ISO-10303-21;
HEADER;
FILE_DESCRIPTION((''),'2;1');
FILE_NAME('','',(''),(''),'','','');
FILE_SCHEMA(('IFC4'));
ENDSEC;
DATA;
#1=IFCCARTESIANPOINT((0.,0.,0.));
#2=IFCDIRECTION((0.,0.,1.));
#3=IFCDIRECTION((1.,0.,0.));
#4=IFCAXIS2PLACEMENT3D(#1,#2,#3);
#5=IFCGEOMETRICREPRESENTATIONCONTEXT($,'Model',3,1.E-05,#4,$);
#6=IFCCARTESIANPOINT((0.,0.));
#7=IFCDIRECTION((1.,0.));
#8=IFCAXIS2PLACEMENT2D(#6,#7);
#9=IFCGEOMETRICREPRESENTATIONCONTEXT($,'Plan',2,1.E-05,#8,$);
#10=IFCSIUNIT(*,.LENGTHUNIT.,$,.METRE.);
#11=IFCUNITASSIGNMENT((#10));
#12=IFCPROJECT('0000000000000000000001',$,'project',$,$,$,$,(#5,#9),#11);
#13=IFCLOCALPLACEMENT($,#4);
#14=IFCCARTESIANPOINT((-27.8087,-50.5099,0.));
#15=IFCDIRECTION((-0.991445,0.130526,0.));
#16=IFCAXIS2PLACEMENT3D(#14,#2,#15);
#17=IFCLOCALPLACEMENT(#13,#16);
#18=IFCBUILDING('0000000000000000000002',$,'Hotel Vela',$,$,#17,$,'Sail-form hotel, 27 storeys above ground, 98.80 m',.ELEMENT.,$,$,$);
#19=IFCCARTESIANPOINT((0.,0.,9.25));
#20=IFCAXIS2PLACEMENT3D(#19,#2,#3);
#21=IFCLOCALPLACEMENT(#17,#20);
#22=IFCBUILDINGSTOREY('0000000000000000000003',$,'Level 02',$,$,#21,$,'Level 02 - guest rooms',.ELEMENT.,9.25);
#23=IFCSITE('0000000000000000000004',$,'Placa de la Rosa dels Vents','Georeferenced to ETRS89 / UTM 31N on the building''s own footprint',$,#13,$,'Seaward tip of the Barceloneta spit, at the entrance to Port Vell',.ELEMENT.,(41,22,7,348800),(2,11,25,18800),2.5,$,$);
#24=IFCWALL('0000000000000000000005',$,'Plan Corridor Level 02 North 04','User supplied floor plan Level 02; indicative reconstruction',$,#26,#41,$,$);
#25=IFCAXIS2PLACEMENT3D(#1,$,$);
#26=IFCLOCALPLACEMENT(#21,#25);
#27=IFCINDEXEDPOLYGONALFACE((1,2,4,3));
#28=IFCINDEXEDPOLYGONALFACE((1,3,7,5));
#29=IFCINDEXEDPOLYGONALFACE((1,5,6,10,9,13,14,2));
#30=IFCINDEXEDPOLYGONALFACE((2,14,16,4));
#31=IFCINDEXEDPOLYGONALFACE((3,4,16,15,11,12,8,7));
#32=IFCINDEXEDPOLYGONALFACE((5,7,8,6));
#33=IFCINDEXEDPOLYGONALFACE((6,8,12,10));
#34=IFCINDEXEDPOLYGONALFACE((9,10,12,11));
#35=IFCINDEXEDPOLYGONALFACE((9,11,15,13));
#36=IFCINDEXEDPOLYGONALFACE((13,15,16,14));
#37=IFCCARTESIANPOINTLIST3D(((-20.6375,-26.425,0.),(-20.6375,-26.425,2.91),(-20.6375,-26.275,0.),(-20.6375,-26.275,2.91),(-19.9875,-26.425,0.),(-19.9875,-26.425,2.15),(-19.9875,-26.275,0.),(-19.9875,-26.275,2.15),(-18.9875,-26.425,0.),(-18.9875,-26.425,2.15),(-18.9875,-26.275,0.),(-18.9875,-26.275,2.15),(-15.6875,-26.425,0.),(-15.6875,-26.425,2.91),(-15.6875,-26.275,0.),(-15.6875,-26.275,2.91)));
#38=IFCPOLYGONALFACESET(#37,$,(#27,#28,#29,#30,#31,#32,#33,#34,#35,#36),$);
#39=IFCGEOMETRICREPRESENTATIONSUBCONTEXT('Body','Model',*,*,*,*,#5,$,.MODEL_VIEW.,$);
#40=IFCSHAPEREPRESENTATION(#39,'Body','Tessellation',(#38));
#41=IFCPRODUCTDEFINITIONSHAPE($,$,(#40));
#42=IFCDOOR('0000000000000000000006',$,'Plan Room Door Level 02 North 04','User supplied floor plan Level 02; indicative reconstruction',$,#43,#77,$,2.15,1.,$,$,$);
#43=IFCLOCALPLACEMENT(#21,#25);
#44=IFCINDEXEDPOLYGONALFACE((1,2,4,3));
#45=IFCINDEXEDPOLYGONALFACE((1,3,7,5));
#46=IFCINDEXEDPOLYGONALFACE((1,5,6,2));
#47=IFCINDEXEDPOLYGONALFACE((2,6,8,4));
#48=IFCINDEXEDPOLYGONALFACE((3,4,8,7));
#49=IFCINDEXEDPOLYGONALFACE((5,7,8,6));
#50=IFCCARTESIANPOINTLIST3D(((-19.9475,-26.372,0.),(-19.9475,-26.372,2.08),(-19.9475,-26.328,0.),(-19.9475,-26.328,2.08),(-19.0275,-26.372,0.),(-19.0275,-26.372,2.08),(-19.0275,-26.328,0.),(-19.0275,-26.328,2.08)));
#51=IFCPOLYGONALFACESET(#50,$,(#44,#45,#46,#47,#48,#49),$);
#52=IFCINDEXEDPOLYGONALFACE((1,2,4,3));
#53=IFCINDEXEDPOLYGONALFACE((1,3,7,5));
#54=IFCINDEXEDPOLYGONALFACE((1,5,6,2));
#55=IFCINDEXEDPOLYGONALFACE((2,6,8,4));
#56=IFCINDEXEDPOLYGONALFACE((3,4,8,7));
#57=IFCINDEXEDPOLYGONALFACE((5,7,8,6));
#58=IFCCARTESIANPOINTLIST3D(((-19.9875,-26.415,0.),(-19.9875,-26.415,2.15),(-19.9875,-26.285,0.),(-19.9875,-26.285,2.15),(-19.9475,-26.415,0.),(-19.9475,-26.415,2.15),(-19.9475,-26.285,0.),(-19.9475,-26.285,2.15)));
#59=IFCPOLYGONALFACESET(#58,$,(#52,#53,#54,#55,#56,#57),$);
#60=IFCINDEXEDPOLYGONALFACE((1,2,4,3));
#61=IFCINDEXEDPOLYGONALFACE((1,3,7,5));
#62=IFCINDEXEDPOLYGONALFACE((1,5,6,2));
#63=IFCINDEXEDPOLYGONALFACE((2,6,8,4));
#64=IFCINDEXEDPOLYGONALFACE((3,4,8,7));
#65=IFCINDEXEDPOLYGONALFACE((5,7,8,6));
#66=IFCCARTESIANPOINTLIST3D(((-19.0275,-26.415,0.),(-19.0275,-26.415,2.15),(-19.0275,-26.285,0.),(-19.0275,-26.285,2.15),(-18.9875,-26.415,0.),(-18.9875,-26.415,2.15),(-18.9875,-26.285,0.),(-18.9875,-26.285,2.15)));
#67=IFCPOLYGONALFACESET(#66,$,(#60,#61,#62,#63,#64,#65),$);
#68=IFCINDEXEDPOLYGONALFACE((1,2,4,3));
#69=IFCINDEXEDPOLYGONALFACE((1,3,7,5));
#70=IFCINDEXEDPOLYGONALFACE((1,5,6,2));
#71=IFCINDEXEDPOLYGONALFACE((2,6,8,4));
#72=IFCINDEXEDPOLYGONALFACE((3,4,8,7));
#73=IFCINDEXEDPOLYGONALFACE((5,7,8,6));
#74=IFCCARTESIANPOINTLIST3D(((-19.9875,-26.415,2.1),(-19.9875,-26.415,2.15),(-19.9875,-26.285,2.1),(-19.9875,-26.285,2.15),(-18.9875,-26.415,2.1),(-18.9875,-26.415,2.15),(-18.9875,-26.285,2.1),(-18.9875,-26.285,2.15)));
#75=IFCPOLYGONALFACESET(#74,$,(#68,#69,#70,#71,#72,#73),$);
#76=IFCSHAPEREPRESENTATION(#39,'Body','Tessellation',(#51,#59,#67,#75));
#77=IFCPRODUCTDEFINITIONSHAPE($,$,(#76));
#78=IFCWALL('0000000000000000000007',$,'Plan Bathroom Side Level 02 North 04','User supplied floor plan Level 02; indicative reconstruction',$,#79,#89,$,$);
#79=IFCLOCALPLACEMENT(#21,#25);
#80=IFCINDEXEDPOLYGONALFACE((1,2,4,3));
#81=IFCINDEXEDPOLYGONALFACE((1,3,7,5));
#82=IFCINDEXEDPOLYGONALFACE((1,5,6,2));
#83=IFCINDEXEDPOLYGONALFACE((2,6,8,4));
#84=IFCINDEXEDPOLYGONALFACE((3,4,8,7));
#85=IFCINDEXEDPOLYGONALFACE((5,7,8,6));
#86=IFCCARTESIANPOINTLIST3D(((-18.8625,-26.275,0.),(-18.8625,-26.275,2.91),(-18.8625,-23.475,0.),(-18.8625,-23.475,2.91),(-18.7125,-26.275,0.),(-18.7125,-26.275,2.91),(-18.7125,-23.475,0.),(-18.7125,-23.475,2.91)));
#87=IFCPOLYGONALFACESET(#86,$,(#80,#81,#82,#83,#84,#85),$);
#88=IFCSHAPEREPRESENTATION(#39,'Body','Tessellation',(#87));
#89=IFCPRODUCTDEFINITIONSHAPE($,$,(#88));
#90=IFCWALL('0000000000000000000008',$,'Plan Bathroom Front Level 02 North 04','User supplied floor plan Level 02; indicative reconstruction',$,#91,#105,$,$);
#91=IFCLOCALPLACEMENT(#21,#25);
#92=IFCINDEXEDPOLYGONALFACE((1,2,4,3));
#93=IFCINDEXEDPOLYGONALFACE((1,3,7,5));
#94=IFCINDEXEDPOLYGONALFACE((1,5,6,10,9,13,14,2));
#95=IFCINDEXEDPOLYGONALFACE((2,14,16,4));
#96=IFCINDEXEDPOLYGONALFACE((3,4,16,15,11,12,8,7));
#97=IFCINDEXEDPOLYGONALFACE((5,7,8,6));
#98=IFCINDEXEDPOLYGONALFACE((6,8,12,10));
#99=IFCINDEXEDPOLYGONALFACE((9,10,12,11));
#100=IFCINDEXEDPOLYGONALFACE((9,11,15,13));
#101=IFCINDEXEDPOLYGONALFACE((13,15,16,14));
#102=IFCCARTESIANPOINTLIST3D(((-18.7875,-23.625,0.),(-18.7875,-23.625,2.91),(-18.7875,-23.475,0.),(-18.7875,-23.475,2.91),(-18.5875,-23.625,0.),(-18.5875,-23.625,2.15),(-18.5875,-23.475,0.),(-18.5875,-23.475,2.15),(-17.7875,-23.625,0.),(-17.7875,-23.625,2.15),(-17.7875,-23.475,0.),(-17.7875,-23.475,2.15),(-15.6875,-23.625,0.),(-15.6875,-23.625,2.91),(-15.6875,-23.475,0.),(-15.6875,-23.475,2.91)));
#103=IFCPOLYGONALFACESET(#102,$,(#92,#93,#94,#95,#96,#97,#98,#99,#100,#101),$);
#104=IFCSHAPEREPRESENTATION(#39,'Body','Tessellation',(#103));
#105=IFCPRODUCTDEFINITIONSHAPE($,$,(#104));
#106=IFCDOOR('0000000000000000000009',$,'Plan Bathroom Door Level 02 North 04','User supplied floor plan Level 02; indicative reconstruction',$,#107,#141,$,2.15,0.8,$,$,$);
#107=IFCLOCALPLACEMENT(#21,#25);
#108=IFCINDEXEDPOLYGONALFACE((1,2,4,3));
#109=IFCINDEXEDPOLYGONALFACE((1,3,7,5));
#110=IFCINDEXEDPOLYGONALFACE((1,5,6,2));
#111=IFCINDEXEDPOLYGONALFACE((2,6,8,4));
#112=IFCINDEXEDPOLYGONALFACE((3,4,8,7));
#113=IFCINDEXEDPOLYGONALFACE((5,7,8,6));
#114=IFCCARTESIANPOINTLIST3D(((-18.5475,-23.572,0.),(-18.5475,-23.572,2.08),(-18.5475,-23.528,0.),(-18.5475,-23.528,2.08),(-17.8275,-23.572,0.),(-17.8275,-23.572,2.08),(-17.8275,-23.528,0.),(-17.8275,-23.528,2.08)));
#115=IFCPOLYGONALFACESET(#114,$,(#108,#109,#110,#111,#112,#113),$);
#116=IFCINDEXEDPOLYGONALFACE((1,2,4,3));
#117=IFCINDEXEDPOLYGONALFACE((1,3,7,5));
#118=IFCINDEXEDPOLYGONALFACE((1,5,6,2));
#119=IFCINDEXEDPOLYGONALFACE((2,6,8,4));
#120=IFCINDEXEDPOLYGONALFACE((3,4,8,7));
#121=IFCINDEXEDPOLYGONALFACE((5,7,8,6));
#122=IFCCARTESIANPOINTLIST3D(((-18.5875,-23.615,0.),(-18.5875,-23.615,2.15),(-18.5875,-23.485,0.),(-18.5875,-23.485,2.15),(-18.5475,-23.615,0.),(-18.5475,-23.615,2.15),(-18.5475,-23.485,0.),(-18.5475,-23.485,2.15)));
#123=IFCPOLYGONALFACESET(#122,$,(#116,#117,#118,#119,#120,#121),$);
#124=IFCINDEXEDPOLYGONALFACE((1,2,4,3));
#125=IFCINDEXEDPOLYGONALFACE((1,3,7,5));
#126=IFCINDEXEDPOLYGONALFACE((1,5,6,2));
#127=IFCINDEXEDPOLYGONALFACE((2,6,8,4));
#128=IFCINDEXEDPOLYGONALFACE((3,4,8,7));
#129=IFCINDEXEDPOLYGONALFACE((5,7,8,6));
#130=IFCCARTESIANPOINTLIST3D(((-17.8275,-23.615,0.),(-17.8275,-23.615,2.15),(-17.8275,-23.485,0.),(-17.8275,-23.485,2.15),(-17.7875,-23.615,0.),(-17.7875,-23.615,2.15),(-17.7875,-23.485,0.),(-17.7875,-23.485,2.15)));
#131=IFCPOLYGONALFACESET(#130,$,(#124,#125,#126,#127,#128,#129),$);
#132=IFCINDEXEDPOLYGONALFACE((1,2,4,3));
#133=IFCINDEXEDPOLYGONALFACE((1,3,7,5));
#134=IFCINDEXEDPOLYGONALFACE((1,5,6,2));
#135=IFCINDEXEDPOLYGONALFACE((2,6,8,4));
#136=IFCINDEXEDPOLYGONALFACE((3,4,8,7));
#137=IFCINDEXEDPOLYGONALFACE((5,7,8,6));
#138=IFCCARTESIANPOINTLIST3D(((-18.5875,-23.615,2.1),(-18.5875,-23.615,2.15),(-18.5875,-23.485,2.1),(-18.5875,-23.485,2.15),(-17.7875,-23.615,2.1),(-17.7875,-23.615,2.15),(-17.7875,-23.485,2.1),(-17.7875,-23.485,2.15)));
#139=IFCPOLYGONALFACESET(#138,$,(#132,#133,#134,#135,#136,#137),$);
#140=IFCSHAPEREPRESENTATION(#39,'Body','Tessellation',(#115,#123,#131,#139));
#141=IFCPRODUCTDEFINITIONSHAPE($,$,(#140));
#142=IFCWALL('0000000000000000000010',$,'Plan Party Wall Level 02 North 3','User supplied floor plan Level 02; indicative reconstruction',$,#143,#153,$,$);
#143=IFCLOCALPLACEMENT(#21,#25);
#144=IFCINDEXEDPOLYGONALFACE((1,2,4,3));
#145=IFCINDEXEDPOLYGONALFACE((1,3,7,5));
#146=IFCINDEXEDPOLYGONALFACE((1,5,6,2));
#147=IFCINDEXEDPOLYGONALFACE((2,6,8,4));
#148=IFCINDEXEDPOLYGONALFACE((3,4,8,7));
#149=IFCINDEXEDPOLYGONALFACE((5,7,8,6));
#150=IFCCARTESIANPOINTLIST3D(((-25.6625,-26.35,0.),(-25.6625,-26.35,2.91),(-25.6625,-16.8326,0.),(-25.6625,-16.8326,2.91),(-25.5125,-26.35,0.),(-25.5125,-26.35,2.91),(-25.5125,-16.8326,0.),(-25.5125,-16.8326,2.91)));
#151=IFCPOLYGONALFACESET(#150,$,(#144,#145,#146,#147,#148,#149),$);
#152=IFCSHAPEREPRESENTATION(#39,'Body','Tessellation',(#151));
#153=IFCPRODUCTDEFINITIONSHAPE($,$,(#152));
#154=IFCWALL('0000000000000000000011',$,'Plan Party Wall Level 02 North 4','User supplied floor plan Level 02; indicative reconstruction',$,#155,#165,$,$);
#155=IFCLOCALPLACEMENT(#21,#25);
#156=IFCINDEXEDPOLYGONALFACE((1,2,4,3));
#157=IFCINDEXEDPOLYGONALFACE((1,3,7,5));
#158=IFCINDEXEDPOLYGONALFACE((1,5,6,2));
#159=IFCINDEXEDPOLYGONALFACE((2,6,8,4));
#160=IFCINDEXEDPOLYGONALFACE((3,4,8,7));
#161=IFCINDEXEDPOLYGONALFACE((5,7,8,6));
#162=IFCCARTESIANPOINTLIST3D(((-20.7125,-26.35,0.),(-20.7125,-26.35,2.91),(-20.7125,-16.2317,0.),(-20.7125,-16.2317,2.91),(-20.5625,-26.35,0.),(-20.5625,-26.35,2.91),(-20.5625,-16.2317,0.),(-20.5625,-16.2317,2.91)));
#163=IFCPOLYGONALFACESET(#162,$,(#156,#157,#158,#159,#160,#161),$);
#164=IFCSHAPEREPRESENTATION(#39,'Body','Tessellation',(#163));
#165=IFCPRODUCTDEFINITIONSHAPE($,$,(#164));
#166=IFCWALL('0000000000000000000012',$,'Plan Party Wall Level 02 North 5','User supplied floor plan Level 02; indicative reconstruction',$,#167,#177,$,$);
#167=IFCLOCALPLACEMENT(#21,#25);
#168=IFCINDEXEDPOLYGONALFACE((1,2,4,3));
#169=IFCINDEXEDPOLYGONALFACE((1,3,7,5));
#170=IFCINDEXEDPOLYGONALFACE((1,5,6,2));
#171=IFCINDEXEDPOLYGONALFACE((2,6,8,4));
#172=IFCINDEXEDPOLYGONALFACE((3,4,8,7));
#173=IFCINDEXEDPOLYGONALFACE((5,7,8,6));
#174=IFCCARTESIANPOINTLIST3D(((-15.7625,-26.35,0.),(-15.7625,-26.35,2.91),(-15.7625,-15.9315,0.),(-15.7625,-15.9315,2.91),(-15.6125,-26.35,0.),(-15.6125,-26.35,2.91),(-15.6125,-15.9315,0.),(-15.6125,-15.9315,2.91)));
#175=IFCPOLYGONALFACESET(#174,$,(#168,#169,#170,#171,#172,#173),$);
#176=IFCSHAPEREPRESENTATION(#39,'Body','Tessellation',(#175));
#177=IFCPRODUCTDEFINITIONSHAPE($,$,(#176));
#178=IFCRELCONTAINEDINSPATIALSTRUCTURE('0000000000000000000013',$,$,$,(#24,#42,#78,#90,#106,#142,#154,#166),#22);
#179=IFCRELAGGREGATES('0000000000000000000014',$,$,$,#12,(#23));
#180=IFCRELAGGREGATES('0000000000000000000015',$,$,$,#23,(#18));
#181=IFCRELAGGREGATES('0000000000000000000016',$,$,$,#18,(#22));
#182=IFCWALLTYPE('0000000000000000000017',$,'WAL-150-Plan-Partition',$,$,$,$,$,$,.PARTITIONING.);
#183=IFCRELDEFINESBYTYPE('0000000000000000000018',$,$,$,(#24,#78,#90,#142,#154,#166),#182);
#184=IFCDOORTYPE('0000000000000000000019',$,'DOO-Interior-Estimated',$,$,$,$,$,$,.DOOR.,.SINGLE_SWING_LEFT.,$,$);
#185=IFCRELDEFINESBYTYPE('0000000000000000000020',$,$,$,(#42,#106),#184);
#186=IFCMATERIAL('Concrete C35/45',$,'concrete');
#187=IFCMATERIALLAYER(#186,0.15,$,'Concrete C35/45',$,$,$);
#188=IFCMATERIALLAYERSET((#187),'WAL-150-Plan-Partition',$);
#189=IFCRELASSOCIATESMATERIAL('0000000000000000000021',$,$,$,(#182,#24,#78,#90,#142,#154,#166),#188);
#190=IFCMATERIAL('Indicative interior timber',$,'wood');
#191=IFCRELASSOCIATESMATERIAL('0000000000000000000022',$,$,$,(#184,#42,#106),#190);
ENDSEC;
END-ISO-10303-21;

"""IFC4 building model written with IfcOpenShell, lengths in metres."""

from ifc_helpers import new_model, si_unit, frame, origin_with_axes, origin_2d_with_axis, place, context, subcontext, project, spatial, line, indexed_curve, outline, extrude, material, layer, layer_set, layer_usage, type_object, element, fill, save


model = new_model("IFC4")

# Units and contexts
model_context = context("Model", 3, precision=1e-05, world=origin_with_axes())
plan_context = context("Plan", 2, precision=1e-05, world=origin_2d_with_axis())
body_context = subcontext(model_context, "Body", "Model", "MODEL_VIEW")
ifc_project = project(units=[si_unit("LENGTHUNIT", "METRE")], contexts=[model_context, plan_context])

# Site, building, storey
site_placement = place(None, origin_with_axes())
site = spatial("IfcSite", under=ifc_project, at=site_placement, Name="Placa de la Rosa dels Vents", Description="Georeferenced to ETRS89 / UTM 31N on the building's own footprint", LongName="Seaward tip of the Barceloneta spit, at the entrance to Port Vell", CompositionType="ELEMENT", RefLatitude=(41, 22, 7, 348800), RefLongitude=(2, 11, 25, 18800), RefElevation=2.5)
building_placement = place(site_placement, frame((-27.8087, -50.5099, 0.0), z_axis=(0.0, 0.0, 1.0), x_axis=(-0.991445, 0.130526, 0.0)))
building = spatial("IfcBuilding", under=site, at=building_placement, Name="Hotel Vela", LongName="Sail-form hotel, 27 storeys above ground, 98.80 m", CompositionType="ELEMENT")
storey_placement = place(building_placement, frame((0.0, 0.0, 9.25), z_axis=(0.0, 0.0, 1.0), x_axis=(1.0, 0.0, 0.0)))
storey = spatial("IfcBuildingStorey", under=building, at=storey_placement, Name="Level 02", LongName="Level 02 - guest rooms", CompositionType="ELEMENT", Elevation=9.25)

# Shared definitions
ifc_material_1 = material(Name="Concrete C35/45", Category="concrete")
ifc_layer = layer(ifc_material_1, 0.15, Name="Concrete C35/45")
ifc_layer_set = layer_set([ifc_layer], Name="WAL-150-Plan-Partition")
wall_type = type_object("IfcWallType", Name="WAL-150-Plan-Partition", PredefinedType="PARTITIONING", material=ifc_layer_set)
ifc_material_2 = material(Name="Indicative interior timber", Category="wood")
door_type = type_object("IfcDoorType", Name="DOO-Interior-Estimated", OperationType="SINGLE_SWING_LEFT", PredefinedType="DOOR", material=ifc_material_2)

# Wall, opening, door
ifc_layer_usage_1 = layer_usage(ifc_layer_set, "AXIS2", "POSITIVE", 0.0)
wall_1_placement = place(storey_placement, frame((-20.6375, -26.425, 0.0), z_axis=(0.0, 0.0, 1.0), x_axis=(1.0, 0.0, 0.0)))
wall_1 = element("IfcWall", 1, at=wall_1_placement, inside=storey, type_object=wall_type, material=ifc_layer_usage_1, Name="Plan Corridor Level 02 North 04", Description="User supplied floor plan Level 02; indicative reconstruction", context=body_context, shape_type="SweptSolid", body=[
    extrude(outline(indexed_curve([(0.0, 0.0), (4.95, 0.0), (4.95, 0.15), (0.0, 0.15)], segments=[line(1, 2, 3, 4, 1)])), origin_with_axes(), (0.0, 0.0, 1.0), 2.91),
])
opening_1_placement = place(wall_1_placement, frame((0.65, -0.085, 0.0), z_axis=(0.0, 0.0, 1.0), x_axis=(1.0, 0.0, 0.0)))
opening_1 = element("IfcOpeningElement", 2, at=opening_1_placement, cuts=wall_1, PredefinedType="OPENING", context=body_context, shape_type="SweptSolid", body=[
    extrude(outline(indexed_curve([(0.0, 0.0), (1.0, 0.0), (1.0, 0.32), (0.0, 0.32)], segments=[line(1, 2, 3, 4, 1)])), origin_with_axes(), (0.0, 0.0, 1.0), 2.15),
])
door_1_placement = place(storey_placement, frame((0.0, 0.0, -9.25), z_axis=(0.0, 0.0, 1.0), x_axis=(1.0, 0.0, 0.0)))
door_1 = element("IfcDoor", 3, at=door_1_placement, inside=storey, type_object=door_type, material=ifc_material_2, Name="Plan Room Door Level 02 North 04", Description="User supplied floor plan Level 02; indicative reconstruction", OverallHeight=2.15, OverallWidth=1.0, context=body_context, shape_type="SweptSolid", body=[
    extrude(outline(indexed_curve([(0.0, 0.0), (0.92, 0.0), (0.92, 0.044), (0.0, 0.044)], segments=[line(1, 2, 3, 4, 1)])), frame((-19.9475, -26.372, 9.25), z_axis=(0.0, 0.0, 1.0), x_axis=(1.0, 0.0, 0.0)), (0.0, 0.0, 1.0), 2.08),
    extrude(outline(indexed_curve([(0.0, 0.0), (0.04, 0.0), (0.04, 0.13), (0.0, 0.13)], segments=[line(1, 2, 3, 4, 1)])), frame((-19.9875, -26.415, 9.25), z_axis=(0.0, 0.0, 1.0), x_axis=(1.0, 0.0, 0.0)), (0.0, 0.0, 1.0), 2.15),
    extrude(outline(indexed_curve([(0.0, 0.0), (0.04, 0.0), (0.04, 0.13), (0.0, 0.13)], segments=[line(1, 2, 3, 4, 1)])), frame((-19.0275, -26.415, 9.25), z_axis=(0.0, 0.0, 1.0), x_axis=(1.0, 0.0, 0.0)), (0.0, 0.0, 1.0), 2.15),
    extrude(outline(indexed_curve([(0.0, 0.0), (1.0, 0.0), (1.0, 0.13), (0.0, 0.13)], segments=[line(1, 2, 3, 4, 1)])), frame((-19.9875, -26.415, 11.35), z_axis=(0.0, 0.0, 1.0), x_axis=(1.0, 0.0, 0.0)), (0.0, 0.0, 1.0), 0.05),
])
fill(opening_1, door_1)

# Wall
ifc_layer_usage_2 = layer_usage(ifc_layer_set, "AXIS2", "POSITIVE", 0.0)
wall_2_placement = place(storey_placement, frame((-18.8625, -26.275, 0.0), z_axis=(0.0, 0.0, 1.0), x_axis=(1.0, 0.0, 0.0)))
element("IfcWall", 4, at=wall_2_placement, inside=storey, type_object=wall_type, material=ifc_layer_usage_2, Name="Plan Bathroom Side Level 02 North 04", Description="User supplied floor plan Level 02; indicative reconstruction", context=body_context, shape_type="SweptSolid", body=[
    extrude(outline(indexed_curve([(0.0, 0.0), (0.15, 0.0), (0.15, 2.8), (0.0, 2.8)], segments=[line(1, 2, 3, 4, 1)])), origin_with_axes(), (0.0, 0.0, 1.0), 2.91),
])

# Wall, opening, door
ifc_layer_usage_3 = layer_usage(ifc_layer_set, "AXIS2", "POSITIVE", 0.0)
wall_3_placement = place(storey_placement, frame((-18.7875, -23.625, 0.0), z_axis=(0.0, 0.0, 1.0), x_axis=(1.0, 0.0, 0.0)))
wall_3 = element("IfcWall", 5, at=wall_3_placement, inside=storey, type_object=wall_type, material=ifc_layer_usage_3, Name="Plan Bathroom Front Level 02 North 04", Description="User supplied floor plan Level 02; indicative reconstruction", context=body_context, shape_type="SweptSolid", body=[
    extrude(outline(indexed_curve([(0.0, 0.0), (3.1, 0.0), (3.1, 0.15), (0.0, 0.15)], segments=[line(1, 2, 3, 4, 1)])), origin_with_axes(), (0.0, 0.0, 1.0), 2.91),
])
opening_2_placement = place(wall_3_placement, frame((0.2, -0.085, 0.0), z_axis=(0.0, 0.0, 1.0), x_axis=(1.0, 0.0, 0.0)))
opening_2 = element("IfcOpeningElement", 6, at=opening_2_placement, cuts=wall_3, PredefinedType="OPENING", context=body_context, shape_type="SweptSolid", body=[
    extrude(outline(indexed_curve([(0.0, 0.0), (0.8, 0.0), (0.8, 0.32), (0.0, 0.32)], segments=[line(1, 2, 3, 4, 1)])), origin_with_axes(), (0.0, 0.0, 1.0), 2.15),
])
door_2_placement = place(storey_placement, frame((0.0, 0.0, -9.25), z_axis=(0.0, 0.0, 1.0), x_axis=(1.0, 0.0, 0.0)))
door_2 = element("IfcDoor", 7, at=door_2_placement, inside=storey, type_object=door_type, material=ifc_material_2, Name="Plan Bathroom Door Level 02 North 04", Description="User supplied floor plan Level 02; indicative reconstruction", OverallHeight=2.15, OverallWidth=0.8, context=body_context, shape_type="SweptSolid", body=[
    extrude(outline(indexed_curve([(0.0, 0.0), (0.72, 0.0), (0.72, 0.044), (0.0, 0.044)], segments=[line(1, 2, 3, 4, 1)])), frame((-18.5475, -23.572, 9.25), z_axis=(0.0, 0.0, 1.0), x_axis=(1.0, 0.0, 0.0)), (0.0, 0.0, 1.0), 2.08),
    extrude(outline(indexed_curve([(0.0, 0.0), (0.04, 0.0), (0.04, 0.13), (0.0, 0.13)], segments=[line(1, 2, 3, 4, 1)])), frame((-18.5875, -23.615, 9.25), z_axis=(0.0, 0.0, 1.0), x_axis=(1.0, 0.0, 0.0)), (0.0, 0.0, 1.0), 2.15),
    extrude(outline(indexed_curve([(0.0, 0.0), (0.04, 0.0), (0.04, 0.13), (0.0, 0.13)], segments=[line(1, 2, 3, 4, 1)])), frame((-17.8275, -23.615, 9.25), z_axis=(0.0, 0.0, 1.0), x_axis=(1.0, 0.0, 0.0)), (0.0, 0.0, 1.0), 2.15),
    extrude(outline(indexed_curve([(0.0, 0.0), (0.8, 0.0), (0.8, 0.13), (0.0, 0.13)], segments=[line(1, 2, 3, 4, 1)])), frame((-18.5875, -23.615, 11.35), z_axis=(0.0, 0.0, 1.0), x_axis=(1.0, 0.0, 0.0)), (0.0, 0.0, 1.0), 0.05),
])
fill(opening_2, door_2)

# Walls
ifc_layer_usage_4 = layer_usage(ifc_layer_set, "AXIS2", "POSITIVE", 0.0)
wall_4_placement = place(storey_placement, frame((-25.6625, -26.35, 0.0), z_axis=(0.0, 0.0, 1.0), x_axis=(1.0, 0.0, 0.0)))
element("IfcWall", 8, at=wall_4_placement, inside=storey, type_object=wall_type, material=ifc_layer_usage_4, Name="Plan Party Wall Level 02 North 3", Description="User supplied floor plan Level 02; indicative reconstruction", context=body_context, shape_type="SweptSolid", body=[
    extrude(outline(indexed_curve([(0.0, 0.0), (0.15, 0.0), (0.15, 9.5174), (0.0, 9.5174)], segments=[line(1, 2, 3, 4, 1)])), origin_with_axes(), (0.0, 0.0, 1.0), 2.91),
])
ifc_layer_usage_5 = layer_usage(ifc_layer_set, "AXIS2", "POSITIVE", 0.0)
wall_5_placement = place(storey_placement, frame((-20.7125, -26.35, 0.0), z_axis=(0.0, 0.0, 1.0), x_axis=(1.0, 0.0, 0.0)))
element("IfcWall", 9, at=wall_5_placement, inside=storey, type_object=wall_type, material=ifc_layer_usage_5, Name="Plan Party Wall Level 02 North 4", Description="User supplied floor plan Level 02; indicative reconstruction", context=body_context, shape_type="SweptSolid", body=[
    extrude(outline(indexed_curve([(0.0, 0.0), (0.15, 0.0), (0.15, 10.1183), (0.0, 10.1183)], segments=[line(1, 2, 3, 4, 1)])), origin_with_axes(), (0.0, 0.0, 1.0), 2.91),
])
ifc_layer_usage_6 = layer_usage(ifc_layer_set, "AXIS2", "POSITIVE", 0.0)
wall_6_placement = place(storey_placement, frame((-15.7625, -26.35, 0.0), z_axis=(0.0, 0.0, 1.0), x_axis=(1.0, 0.0, 0.0)))
element("IfcWall", 10, at=wall_6_placement, inside=storey, type_object=wall_type, material=ifc_layer_usage_6, Name="Plan Party Wall Level 02 North 5", Description="User supplied floor plan Level 02; indicative reconstruction", context=body_context, shape_type="SweptSolid", body=[
    extrude(outline(indexed_curve([(0.0, 0.0), (0.15, 0.0), (0.15, 10.4185), (0.0, 10.4185)], segments=[line(1, 2, 3, 4, 1)])), origin_with_axes(), (0.0, 0.0, 1.0), 2.91),
])

save(model, "model.ifc")
